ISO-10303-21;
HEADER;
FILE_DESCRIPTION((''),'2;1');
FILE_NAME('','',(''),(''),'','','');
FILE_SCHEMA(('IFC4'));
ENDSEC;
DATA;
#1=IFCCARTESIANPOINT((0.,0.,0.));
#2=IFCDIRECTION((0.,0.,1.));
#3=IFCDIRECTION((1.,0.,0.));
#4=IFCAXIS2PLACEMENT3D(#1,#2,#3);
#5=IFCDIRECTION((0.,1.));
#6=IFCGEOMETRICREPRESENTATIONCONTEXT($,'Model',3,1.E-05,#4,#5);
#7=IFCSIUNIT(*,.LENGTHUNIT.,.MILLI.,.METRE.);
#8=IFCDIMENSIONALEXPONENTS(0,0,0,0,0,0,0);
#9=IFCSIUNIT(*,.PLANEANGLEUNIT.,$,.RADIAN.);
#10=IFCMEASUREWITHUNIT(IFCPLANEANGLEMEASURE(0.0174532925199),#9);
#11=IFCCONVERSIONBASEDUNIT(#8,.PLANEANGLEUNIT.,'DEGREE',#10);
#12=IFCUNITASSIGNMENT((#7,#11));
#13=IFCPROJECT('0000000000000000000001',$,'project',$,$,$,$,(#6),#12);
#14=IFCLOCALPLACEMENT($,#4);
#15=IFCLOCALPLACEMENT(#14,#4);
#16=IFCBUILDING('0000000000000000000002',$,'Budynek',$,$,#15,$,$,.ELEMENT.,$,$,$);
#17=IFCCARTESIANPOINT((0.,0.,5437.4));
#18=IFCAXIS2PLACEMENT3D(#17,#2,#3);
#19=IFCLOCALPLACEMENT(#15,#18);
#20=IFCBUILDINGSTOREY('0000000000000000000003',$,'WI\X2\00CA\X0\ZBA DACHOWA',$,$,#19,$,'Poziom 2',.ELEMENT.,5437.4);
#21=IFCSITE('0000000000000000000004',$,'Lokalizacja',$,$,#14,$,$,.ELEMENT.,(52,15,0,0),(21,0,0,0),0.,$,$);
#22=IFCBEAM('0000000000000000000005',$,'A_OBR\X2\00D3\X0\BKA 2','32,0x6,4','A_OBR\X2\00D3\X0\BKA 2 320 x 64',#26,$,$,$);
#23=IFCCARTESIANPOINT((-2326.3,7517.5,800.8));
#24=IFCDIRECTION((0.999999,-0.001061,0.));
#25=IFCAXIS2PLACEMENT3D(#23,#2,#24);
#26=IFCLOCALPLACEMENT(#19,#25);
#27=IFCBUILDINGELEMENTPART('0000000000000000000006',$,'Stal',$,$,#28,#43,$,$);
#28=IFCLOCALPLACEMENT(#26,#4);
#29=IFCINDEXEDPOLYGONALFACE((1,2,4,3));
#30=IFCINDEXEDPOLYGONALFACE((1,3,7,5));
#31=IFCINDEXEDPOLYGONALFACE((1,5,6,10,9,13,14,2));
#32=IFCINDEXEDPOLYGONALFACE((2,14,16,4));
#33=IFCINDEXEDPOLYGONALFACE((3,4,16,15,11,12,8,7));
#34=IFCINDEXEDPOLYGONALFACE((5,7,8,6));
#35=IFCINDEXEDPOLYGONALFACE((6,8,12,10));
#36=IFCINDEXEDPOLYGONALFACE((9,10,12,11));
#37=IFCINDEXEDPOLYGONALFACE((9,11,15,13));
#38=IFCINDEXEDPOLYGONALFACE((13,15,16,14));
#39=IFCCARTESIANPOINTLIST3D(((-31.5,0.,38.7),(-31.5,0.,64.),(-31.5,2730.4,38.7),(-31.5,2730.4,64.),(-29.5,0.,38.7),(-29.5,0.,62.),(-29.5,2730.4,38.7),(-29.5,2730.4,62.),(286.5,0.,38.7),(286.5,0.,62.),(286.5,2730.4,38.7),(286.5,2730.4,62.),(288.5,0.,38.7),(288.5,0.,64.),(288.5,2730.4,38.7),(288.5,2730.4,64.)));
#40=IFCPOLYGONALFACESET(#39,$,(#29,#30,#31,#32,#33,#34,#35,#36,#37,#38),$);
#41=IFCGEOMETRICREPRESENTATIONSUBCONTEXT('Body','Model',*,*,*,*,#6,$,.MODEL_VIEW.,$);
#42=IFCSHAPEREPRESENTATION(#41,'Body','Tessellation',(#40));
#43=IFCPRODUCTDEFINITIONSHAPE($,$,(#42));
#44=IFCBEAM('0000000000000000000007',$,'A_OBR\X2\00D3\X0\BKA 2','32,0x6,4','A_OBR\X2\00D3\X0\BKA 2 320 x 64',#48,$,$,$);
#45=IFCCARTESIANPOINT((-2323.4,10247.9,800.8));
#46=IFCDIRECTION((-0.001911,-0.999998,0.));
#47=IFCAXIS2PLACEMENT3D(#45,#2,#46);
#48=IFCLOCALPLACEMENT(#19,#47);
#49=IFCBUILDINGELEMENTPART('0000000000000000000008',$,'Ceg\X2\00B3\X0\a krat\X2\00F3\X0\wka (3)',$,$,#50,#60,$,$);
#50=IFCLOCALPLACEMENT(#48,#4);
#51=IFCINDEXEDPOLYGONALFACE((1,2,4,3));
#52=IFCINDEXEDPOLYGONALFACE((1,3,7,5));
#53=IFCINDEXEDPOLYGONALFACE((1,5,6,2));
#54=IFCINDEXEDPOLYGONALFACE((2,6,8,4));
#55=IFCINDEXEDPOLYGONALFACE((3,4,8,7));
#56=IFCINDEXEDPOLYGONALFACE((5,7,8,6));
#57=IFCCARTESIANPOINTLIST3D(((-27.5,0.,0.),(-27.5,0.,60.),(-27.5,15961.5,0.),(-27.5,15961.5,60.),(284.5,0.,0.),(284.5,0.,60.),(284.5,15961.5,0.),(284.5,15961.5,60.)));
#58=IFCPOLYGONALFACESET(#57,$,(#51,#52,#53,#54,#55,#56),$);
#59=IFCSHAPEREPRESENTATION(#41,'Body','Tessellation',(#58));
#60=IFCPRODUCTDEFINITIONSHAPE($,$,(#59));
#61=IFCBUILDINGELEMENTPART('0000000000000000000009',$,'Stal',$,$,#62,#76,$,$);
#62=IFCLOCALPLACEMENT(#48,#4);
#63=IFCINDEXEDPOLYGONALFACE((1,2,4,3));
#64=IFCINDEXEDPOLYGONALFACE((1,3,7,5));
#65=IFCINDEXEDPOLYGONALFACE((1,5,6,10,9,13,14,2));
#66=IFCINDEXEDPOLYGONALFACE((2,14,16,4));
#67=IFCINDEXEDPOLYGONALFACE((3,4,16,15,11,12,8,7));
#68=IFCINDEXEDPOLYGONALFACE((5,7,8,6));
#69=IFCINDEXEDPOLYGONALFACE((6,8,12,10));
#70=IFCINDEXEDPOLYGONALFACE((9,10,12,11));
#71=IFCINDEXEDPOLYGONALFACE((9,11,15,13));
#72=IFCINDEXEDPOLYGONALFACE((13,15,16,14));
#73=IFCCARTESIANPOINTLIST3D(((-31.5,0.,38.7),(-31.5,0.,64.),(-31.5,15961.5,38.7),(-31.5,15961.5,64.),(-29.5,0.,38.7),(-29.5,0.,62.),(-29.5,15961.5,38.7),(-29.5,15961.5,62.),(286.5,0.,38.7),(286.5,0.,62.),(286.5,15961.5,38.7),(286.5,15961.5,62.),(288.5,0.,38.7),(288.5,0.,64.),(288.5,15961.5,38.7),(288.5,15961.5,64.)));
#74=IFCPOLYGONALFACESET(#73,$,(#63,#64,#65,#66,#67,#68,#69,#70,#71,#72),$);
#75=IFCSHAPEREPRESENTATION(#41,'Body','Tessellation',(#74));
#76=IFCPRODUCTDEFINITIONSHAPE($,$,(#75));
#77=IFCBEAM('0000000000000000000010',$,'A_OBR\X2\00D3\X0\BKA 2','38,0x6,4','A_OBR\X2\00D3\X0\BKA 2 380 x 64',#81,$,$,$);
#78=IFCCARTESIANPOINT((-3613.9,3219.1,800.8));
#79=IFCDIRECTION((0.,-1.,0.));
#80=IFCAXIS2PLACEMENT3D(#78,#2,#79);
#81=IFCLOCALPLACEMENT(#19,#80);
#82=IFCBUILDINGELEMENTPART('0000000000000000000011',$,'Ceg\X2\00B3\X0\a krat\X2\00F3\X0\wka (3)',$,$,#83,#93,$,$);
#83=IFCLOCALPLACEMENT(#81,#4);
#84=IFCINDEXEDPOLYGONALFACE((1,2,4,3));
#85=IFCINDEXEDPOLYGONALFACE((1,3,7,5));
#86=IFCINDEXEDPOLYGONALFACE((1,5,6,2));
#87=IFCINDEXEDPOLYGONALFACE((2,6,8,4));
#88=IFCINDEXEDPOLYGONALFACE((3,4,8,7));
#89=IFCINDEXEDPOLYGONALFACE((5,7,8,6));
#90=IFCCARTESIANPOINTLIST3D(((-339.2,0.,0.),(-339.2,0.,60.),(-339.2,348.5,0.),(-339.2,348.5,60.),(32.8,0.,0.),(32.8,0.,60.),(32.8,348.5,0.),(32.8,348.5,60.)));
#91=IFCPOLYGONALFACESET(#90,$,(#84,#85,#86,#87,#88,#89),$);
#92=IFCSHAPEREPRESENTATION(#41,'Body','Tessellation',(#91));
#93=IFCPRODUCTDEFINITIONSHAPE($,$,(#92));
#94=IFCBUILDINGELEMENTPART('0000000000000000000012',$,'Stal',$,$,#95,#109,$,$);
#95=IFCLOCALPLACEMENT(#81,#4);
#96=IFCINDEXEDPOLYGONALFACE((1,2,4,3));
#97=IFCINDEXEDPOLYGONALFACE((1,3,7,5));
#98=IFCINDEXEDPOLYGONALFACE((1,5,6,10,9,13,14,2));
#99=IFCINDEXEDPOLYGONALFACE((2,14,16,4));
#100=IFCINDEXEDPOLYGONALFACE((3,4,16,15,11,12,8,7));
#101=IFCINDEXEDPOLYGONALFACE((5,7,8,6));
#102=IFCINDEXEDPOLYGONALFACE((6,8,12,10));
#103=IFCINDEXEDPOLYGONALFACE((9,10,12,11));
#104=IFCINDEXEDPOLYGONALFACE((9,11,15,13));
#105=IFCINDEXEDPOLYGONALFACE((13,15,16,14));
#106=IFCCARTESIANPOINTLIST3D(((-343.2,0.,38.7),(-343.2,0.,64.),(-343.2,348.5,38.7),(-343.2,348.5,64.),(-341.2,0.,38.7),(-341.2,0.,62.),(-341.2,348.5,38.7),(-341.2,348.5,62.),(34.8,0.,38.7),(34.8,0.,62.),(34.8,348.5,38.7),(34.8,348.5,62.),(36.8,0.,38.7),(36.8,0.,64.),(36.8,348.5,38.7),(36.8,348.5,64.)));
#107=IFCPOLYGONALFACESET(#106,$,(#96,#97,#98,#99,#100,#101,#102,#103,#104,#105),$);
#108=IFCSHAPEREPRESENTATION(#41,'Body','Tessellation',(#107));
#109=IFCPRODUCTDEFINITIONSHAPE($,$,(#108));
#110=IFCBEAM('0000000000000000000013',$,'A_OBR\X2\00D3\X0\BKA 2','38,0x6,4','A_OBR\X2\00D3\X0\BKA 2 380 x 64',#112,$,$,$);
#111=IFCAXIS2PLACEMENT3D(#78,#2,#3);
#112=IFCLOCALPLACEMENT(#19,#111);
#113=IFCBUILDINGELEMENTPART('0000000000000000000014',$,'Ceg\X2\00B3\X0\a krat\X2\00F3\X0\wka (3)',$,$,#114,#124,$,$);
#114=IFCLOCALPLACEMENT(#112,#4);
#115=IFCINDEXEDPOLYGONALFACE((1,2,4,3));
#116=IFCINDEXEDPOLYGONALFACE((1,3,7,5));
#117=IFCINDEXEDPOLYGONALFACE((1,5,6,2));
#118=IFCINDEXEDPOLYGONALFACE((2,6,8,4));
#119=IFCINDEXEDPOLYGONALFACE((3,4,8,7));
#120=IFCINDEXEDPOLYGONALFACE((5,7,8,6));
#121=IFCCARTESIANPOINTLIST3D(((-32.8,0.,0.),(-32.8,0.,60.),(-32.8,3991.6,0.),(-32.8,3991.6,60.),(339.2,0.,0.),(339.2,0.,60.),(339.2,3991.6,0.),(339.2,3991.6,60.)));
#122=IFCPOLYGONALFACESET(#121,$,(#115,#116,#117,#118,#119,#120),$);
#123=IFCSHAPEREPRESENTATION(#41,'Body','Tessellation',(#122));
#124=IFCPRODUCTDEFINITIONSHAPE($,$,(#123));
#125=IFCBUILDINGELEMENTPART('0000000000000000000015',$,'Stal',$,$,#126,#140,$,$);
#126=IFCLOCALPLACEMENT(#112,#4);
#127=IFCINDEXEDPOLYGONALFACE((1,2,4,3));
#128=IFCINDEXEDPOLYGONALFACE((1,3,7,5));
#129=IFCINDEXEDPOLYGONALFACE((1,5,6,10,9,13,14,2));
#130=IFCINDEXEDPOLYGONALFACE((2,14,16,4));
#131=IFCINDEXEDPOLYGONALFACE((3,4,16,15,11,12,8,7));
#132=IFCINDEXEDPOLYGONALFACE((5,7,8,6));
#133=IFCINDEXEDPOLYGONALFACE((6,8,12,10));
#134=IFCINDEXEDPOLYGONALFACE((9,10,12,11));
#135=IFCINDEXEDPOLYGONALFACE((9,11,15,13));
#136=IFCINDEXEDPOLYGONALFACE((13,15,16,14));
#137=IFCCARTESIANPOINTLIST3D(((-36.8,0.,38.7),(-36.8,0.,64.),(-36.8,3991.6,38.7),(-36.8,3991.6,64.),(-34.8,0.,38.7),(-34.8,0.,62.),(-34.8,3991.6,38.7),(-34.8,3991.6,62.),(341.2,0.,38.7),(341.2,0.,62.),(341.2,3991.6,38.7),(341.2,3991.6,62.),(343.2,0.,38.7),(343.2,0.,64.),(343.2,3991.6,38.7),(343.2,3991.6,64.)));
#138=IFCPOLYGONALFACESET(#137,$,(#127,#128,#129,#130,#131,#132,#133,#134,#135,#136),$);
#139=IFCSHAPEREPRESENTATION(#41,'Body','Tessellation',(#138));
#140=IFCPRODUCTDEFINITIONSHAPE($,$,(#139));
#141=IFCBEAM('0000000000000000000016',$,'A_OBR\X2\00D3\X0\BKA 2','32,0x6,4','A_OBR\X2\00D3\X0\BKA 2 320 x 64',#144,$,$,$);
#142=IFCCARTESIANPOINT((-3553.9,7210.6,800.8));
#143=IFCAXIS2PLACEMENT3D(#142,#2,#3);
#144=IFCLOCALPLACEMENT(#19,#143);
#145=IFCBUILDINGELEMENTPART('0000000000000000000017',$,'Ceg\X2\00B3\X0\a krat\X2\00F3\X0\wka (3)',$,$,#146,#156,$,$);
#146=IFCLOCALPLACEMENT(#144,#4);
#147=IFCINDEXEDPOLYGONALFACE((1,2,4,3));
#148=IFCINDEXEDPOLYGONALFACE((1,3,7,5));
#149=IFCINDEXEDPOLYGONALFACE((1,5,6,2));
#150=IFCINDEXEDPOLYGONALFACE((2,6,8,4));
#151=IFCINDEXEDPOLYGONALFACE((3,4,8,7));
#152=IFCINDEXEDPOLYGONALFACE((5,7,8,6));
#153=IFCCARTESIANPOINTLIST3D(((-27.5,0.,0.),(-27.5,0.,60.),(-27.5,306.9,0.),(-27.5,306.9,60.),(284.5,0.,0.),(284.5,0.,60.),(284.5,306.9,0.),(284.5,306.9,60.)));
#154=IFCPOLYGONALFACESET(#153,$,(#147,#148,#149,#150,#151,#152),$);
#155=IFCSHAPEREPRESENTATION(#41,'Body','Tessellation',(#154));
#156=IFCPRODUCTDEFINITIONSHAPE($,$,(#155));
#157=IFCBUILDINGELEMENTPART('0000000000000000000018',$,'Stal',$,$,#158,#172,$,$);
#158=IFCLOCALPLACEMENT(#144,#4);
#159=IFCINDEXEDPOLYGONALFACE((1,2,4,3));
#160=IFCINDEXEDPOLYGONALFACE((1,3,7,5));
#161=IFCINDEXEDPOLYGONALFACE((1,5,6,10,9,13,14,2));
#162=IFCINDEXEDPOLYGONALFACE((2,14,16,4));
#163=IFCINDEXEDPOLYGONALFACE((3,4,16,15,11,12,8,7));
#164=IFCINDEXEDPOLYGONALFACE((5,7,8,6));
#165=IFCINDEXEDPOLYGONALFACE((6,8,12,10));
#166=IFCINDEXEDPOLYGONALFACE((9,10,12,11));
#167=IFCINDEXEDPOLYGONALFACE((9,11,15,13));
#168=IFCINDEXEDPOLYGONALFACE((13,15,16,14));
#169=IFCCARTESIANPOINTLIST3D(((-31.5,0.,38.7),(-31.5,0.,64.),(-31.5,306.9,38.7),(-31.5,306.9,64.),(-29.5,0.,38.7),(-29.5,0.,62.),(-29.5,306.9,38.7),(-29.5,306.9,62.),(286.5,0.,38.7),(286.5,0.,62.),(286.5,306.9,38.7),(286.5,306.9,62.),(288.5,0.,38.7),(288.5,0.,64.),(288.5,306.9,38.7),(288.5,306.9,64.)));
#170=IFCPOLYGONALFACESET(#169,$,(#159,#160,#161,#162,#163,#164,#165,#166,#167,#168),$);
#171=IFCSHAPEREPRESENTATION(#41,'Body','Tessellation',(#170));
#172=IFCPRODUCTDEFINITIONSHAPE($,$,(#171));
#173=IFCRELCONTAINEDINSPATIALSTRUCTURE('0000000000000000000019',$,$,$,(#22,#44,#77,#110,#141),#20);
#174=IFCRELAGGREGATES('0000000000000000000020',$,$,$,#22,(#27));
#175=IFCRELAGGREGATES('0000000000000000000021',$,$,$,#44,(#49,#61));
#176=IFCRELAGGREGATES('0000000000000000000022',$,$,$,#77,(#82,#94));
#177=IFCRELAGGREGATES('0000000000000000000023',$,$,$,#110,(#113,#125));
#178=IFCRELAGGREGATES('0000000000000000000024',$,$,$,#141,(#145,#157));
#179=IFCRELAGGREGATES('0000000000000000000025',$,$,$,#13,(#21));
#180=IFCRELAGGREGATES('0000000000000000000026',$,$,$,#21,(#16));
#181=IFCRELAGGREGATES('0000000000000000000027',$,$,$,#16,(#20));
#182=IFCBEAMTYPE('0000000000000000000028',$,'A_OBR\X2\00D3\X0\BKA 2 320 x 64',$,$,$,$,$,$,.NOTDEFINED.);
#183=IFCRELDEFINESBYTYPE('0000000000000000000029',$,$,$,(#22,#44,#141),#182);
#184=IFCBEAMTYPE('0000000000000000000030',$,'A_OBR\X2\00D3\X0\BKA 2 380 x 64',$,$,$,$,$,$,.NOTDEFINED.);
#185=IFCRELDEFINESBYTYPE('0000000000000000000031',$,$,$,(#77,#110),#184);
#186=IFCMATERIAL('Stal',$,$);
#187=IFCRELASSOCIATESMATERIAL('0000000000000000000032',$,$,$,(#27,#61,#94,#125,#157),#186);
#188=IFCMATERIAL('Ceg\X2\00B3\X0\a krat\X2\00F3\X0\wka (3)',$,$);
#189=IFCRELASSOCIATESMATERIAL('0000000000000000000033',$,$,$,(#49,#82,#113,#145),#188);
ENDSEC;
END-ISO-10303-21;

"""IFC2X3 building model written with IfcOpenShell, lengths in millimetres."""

from ifc_helpers import new_model, entity, si_unit, converted_unit, direction, frame, origin_with_axes, place, context, subcontext, project, spatial, polyline, outline, extrude, material, type_object, element, aggregate, save


model = new_model("IFC2X3")

# Units and contexts
model_context = context("Model", 3, precision=1e-05, world=origin_with_axes(), true_north=direction((0.0, 1.0)))
body_context = subcontext(model_context, "Body", "Model", "MODEL_VIEW")
ifc_project = project(units=[si_unit("LENGTHUNIT", "METRE", prefix="MILLI"), converted_unit("PLANEANGLEUNIT", "DEGREE", entity("IfcPlaneAngleMeasure", 0.0174532925199), si_unit("PLANEANGLEUNIT", "RADIAN"), dimensions=[0, 0, 0, 0, 0, 0, 0])], contexts=[model_context])

# Site, building, storey
site_placement = place(None, origin_with_axes())
site = spatial("IfcSite", under=ifc_project, at=site_placement, Name="Lokalizacja", CompositionType="ELEMENT", RefLatitude=(52, 15, 0, 0), RefLongitude=(21, 0, 0, 0), RefElevation=0.0)
building_placement = place(site_placement, origin_with_axes())
building = spatial("IfcBuilding", under=site, at=building_placement, Name="Budynek", CompositionType="ELEMENT")
storey_placement = place(building_placement, frame((0.0, 0.0, 5437.4), z_axis=(0.0, 0.0, 1.0), x_axis=(1.0, 0.0, 0.0)))
storey = spatial("IfcBuildingStorey", under=building, at=storey_placement, Name="WIÊZBA DACHOWA", LongName="Poziom 2", CompositionType="ELEMENT", Elevation=5437.4)

# Shared definitions
beam_type_1 = type_object("IfcBeamType", Name="A_OBRÓBKA 2 380 x 64", PredefinedType="NOTDEFINED")
ifc_material_1 = material(Name="Ceg³a kratówka (3)")
ifc_material_2 = material(Name="Stal")

# Shared definitions
beam_type_2 = type_object("IfcBeamType", Name="A_OBRÓBKA 2 320 x 64", PredefinedType="NOTDEFINED")

# Beams, building element parts
beam_1_placement = place(storey_placement, frame((-2326.3, 7517.5, 800.8), z_axis=(0.0, 0.0, 1.0), x_axis=(0.999999, -0.001061, 0.0)))
beam_1 = element("IfcBeam", 1, at=beam_1_placement, inside=storey, type_object=beam_type_2, Name="A_OBRÓBKA 2", Description="32,0x6,4", ObjectType="A_OBRÓBKA 2 320 x 64")
building_element_part_1_placement = place(beam_1_placement, origin_with_axes())
building_element_part_1 = element("IfcBuildingElementPart", 2, at=building_element_part_1_placement, material=ifc_material_2, Name="Stal", context=body_context, shape_type="SweptSolid", body=[
    extrude(outline(polyline([(-31.5, 64.0), (-31.5, 38.7), (-29.5, 38.7), (-29.5, 62.0), (286.5, 62.0), (286.5, 38.7), (288.5, 38.7), (288.5, 64.0), (-31.5, 64.0)])), frame((0.0, 2730.4, 0.0), z_axis=(0.0, -1.0, 0.0), x_axis=(1.0, 0.0, 0.0)), (0.0, 0.0, 1.0), 2730.4),
])
aggregate(beam_1, [building_element_part_1])
beam_2_placement = place(storey_placement, frame((-2323.4, 10247.9, 800.8), z_axis=(0.0, 0.0, 1.0), x_axis=(-0.001911, -0.999998, 0.0)))
beam_2 = element("IfcBeam", 3, at=beam_2_placement, inside=storey, type_object=beam_type_2, Name="A_OBRÓBKA 2", Description="32,0x6,4", ObjectType="A_OBRÓBKA 2 320 x 64")
building_element_part_2_placement = place(beam_2_placement, origin_with_axes())
building_element_part_2 = element("IfcBuildingElementPart", 4, at=building_element_part_2_placement, material=ifc_material_1, Name="Ceg³a kratówka (3)", context=body_context, shape_type="SweptSolid", body=[
    extrude(outline(polyline([(284.5, 0.0), (284.5, 60.0), (-27.5, 60.0), (-27.5, 0.0), (284.5, 0.0)])), frame((0.0, 15961.5, 0.0), z_axis=(0.0, -1.0, 0.0), x_axis=(1.0, 0.0, 0.0)), (0.0, 0.0, 1.0), 15961.5),
])
building_element_part_3_placement = place(beam_2_placement, origin_with_axes())
building_element_part_3 = element("IfcBuildingElementPart", 5, at=building_element_part_3_placement, material=ifc_material_2, Name="Stal", context=body_context, shape_type="SweptSolid", body=[
    extrude(outline(polyline([(-31.5, 64.0), (-31.5, 38.7), (-29.5, 38.7), (-29.5, 62.0), (286.5, 62.0), (286.5, 38.7), (288.5, 38.7), (288.5, 64.0), (-31.5, 64.0)])), frame((0.0, 15961.5, 0.0), z_axis=(0.0, -1.0, 0.0), x_axis=(1.0, 0.0, 0.0)), (0.0, 0.0, 1.0), 15961.5),
])
aggregate(beam_2, [building_element_part_2, building_element_part_3])
beam_3_placement = place(storey_placement, frame((-3613.9, 3219.1, 800.8), z_axis=(0.0, 0.0, 1.0), x_axis=(0.0, -1.0, 0.0)))
beam_3 = element("IfcBeam", 6, at=beam_3_placement, inside=storey, type_object=beam_type_1, Name="A_OBRÓBKA 2", Description="38,0x6,4", ObjectType="A_OBRÓBKA 2 380 x 64")
building_element_part_4_placement = place(beam_3_placement, origin_with_axes())
building_element_part_4 = element("IfcBuildingElementPart", 7, at=building_element_part_4_placement, material=ifc_material_1, Name="Ceg³a kratówka (3)", context=body_context, shape_type="SweptSolid", body=[
    extrude(outline(polyline([(-339.2, 0.0), (32.8, 0.0), (32.8, 60.0), (-339.2, 60.0), (-339.2, 0.0)])), frame((0.0, 348.5, 0.0), z_axis=(0.0, -1.0, 0.0), x_axis=(1.0, 0.0, 0.0)), (0.0, 0.0, 1.0), 348.5),
])
building_element_part_5_placement = place(beam_3_placement, origin_with_axes())
building_element_part_5 = element("IfcBuildingElementPart", 8, at=building_element_part_5_placement, material=ifc_material_2, Name="Stal", context=body_context, shape_type="SweptSolid", body=[
    extrude(outline(polyline([(36.8, 64.0), (-343.2, 64.0), (-343.2, 38.7), (-341.2, 38.7), (-341.2, 62.0), (34.8, 62.0), (34.8, 38.7), (36.8, 38.7), (36.8, 64.0)])), frame((0.0, 348.5, 0.0), z_axis=(0.0, -1.0, 0.0), x_axis=(1.0, 0.0, 0.0)), (0.0, 0.0, 1.0), 348.5),
])
aggregate(beam_3, [building_element_part_4, building_element_part_5])
beam_4_placement = place(storey_placement, frame((-3613.9, 3219.1, 800.8), z_axis=(0.0, 0.0, 1.0), x_axis=(1.0, 0.0, 0.0)))
beam_4 = element("IfcBeam", 9, at=beam_4_placement, inside=storey, type_object=beam_type_1, Name="A_OBRÓBKA 2", Description="38,0x6,4", ObjectType="A_OBRÓBKA 2 380 x 64")
building_element_part_6_placement = place(beam_4_placement, origin_with_axes())
building_element_part_6 = element("IfcBuildingElementPart", 10, at=building_element_part_6_placement, material=ifc_material_1, Name="Ceg³a kratówka (3)", context=body_context, shape_type="SweptSolid", body=[
    extrude(outline(polyline([(339.2, 0.0), (339.2, 60.0), (-32.8, 60.0), (-32.8, 0.0), (339.2, 0.0)])), frame((0.0, 3991.6, 0.0), z_axis=(0.0, -1.0, 0.0), x_axis=(1.0, 0.0, 0.0)), (0.0, 0.0, 1.0), 3991.6),
])
building_element_part_7_placement = place(beam_4_placement, origin_with_axes())
building_element_part_7 = element("IfcBuildingElementPart", 11, at=building_element_part_7_placement, material=ifc_material_2, Name="Stal", context=body_context, shape_type="SweptSolid", body=[
    extrude(outline(polyline([(-36.8, 64.0), (-36.8, 38.7), (-34.8, 38.7), (-34.8, 62.0), (341.2, 62.0), (341.2, 38.7), (343.2, 38.7), (343.2, 64.0), (-36.8, 64.0)])), frame((0.0, 3991.6, 0.0), z_axis=(0.0, -1.0, 0.0), x_axis=(1.0, 0.0, 0.0)), (0.0, 0.0, 1.0), 3991.6),
])
aggregate(beam_4, [building_element_part_6, building_element_part_7])
beam_5_placement = place(storey_placement, frame((-3553.9, 7210.6, 800.8), z_axis=(0.0, 0.0, 1.0), x_axis=(1.0, 0.0, 0.0)))
beam_5 = element("IfcBeam", 12, at=beam_5_placement, inside=storey, type_object=beam_type_2, Name="A_OBRÓBKA 2", Description="32,0x6,4", ObjectType="A_OBRÓBKA 2 320 x 64")
building_element_part_8_placement = place(beam_5_placement, origin_with_axes())
building_element_part_8 = element("IfcBuildingElementPart", 13, at=building_element_part_8_placement, material=ifc_material_1, Name="Ceg³a kratówka (3)", context=body_context, shape_type="SweptSolid", body=[
    extrude(outline(polyline([(284.5, 0.0), (284.5, 60.0), (-27.5, 60.0), (-27.5, 0.0), (284.5, 0.0)])), frame((0.0, 306.9, 0.0), z_axis=(0.0, -1.0, 0.0), x_axis=(1.0, 0.0, 0.0)), (0.0, 0.0, 1.0), 306.9),
])
building_element_part_9_placement = place(beam_5_placement, origin_with_axes())
building_element_part_9 = element("IfcBuildingElementPart", 14, at=building_element_part_9_placement, material=ifc_material_2, Name="Stal", context=body_context, shape_type="SweptSolid", body=[
    extrude(outline(polyline([(-31.5, 64.0), (-31.5, 38.7), (-29.5, 38.7), (-29.5, 62.0), (286.5, 62.0), (286.5, 38.7), (288.5, 38.7), (288.5, 64.0), (-31.5, 64.0)])), frame((0.0, 306.9, 0.0), z_axis=(0.0, -1.0, 0.0), x_axis=(1.0, 0.0, 0.0)), (0.0, 0.0, 1.0), 306.9),
])
aggregate(beam_5, [building_element_part_8, building_element_part_9])

save(model, "model.ifc")
